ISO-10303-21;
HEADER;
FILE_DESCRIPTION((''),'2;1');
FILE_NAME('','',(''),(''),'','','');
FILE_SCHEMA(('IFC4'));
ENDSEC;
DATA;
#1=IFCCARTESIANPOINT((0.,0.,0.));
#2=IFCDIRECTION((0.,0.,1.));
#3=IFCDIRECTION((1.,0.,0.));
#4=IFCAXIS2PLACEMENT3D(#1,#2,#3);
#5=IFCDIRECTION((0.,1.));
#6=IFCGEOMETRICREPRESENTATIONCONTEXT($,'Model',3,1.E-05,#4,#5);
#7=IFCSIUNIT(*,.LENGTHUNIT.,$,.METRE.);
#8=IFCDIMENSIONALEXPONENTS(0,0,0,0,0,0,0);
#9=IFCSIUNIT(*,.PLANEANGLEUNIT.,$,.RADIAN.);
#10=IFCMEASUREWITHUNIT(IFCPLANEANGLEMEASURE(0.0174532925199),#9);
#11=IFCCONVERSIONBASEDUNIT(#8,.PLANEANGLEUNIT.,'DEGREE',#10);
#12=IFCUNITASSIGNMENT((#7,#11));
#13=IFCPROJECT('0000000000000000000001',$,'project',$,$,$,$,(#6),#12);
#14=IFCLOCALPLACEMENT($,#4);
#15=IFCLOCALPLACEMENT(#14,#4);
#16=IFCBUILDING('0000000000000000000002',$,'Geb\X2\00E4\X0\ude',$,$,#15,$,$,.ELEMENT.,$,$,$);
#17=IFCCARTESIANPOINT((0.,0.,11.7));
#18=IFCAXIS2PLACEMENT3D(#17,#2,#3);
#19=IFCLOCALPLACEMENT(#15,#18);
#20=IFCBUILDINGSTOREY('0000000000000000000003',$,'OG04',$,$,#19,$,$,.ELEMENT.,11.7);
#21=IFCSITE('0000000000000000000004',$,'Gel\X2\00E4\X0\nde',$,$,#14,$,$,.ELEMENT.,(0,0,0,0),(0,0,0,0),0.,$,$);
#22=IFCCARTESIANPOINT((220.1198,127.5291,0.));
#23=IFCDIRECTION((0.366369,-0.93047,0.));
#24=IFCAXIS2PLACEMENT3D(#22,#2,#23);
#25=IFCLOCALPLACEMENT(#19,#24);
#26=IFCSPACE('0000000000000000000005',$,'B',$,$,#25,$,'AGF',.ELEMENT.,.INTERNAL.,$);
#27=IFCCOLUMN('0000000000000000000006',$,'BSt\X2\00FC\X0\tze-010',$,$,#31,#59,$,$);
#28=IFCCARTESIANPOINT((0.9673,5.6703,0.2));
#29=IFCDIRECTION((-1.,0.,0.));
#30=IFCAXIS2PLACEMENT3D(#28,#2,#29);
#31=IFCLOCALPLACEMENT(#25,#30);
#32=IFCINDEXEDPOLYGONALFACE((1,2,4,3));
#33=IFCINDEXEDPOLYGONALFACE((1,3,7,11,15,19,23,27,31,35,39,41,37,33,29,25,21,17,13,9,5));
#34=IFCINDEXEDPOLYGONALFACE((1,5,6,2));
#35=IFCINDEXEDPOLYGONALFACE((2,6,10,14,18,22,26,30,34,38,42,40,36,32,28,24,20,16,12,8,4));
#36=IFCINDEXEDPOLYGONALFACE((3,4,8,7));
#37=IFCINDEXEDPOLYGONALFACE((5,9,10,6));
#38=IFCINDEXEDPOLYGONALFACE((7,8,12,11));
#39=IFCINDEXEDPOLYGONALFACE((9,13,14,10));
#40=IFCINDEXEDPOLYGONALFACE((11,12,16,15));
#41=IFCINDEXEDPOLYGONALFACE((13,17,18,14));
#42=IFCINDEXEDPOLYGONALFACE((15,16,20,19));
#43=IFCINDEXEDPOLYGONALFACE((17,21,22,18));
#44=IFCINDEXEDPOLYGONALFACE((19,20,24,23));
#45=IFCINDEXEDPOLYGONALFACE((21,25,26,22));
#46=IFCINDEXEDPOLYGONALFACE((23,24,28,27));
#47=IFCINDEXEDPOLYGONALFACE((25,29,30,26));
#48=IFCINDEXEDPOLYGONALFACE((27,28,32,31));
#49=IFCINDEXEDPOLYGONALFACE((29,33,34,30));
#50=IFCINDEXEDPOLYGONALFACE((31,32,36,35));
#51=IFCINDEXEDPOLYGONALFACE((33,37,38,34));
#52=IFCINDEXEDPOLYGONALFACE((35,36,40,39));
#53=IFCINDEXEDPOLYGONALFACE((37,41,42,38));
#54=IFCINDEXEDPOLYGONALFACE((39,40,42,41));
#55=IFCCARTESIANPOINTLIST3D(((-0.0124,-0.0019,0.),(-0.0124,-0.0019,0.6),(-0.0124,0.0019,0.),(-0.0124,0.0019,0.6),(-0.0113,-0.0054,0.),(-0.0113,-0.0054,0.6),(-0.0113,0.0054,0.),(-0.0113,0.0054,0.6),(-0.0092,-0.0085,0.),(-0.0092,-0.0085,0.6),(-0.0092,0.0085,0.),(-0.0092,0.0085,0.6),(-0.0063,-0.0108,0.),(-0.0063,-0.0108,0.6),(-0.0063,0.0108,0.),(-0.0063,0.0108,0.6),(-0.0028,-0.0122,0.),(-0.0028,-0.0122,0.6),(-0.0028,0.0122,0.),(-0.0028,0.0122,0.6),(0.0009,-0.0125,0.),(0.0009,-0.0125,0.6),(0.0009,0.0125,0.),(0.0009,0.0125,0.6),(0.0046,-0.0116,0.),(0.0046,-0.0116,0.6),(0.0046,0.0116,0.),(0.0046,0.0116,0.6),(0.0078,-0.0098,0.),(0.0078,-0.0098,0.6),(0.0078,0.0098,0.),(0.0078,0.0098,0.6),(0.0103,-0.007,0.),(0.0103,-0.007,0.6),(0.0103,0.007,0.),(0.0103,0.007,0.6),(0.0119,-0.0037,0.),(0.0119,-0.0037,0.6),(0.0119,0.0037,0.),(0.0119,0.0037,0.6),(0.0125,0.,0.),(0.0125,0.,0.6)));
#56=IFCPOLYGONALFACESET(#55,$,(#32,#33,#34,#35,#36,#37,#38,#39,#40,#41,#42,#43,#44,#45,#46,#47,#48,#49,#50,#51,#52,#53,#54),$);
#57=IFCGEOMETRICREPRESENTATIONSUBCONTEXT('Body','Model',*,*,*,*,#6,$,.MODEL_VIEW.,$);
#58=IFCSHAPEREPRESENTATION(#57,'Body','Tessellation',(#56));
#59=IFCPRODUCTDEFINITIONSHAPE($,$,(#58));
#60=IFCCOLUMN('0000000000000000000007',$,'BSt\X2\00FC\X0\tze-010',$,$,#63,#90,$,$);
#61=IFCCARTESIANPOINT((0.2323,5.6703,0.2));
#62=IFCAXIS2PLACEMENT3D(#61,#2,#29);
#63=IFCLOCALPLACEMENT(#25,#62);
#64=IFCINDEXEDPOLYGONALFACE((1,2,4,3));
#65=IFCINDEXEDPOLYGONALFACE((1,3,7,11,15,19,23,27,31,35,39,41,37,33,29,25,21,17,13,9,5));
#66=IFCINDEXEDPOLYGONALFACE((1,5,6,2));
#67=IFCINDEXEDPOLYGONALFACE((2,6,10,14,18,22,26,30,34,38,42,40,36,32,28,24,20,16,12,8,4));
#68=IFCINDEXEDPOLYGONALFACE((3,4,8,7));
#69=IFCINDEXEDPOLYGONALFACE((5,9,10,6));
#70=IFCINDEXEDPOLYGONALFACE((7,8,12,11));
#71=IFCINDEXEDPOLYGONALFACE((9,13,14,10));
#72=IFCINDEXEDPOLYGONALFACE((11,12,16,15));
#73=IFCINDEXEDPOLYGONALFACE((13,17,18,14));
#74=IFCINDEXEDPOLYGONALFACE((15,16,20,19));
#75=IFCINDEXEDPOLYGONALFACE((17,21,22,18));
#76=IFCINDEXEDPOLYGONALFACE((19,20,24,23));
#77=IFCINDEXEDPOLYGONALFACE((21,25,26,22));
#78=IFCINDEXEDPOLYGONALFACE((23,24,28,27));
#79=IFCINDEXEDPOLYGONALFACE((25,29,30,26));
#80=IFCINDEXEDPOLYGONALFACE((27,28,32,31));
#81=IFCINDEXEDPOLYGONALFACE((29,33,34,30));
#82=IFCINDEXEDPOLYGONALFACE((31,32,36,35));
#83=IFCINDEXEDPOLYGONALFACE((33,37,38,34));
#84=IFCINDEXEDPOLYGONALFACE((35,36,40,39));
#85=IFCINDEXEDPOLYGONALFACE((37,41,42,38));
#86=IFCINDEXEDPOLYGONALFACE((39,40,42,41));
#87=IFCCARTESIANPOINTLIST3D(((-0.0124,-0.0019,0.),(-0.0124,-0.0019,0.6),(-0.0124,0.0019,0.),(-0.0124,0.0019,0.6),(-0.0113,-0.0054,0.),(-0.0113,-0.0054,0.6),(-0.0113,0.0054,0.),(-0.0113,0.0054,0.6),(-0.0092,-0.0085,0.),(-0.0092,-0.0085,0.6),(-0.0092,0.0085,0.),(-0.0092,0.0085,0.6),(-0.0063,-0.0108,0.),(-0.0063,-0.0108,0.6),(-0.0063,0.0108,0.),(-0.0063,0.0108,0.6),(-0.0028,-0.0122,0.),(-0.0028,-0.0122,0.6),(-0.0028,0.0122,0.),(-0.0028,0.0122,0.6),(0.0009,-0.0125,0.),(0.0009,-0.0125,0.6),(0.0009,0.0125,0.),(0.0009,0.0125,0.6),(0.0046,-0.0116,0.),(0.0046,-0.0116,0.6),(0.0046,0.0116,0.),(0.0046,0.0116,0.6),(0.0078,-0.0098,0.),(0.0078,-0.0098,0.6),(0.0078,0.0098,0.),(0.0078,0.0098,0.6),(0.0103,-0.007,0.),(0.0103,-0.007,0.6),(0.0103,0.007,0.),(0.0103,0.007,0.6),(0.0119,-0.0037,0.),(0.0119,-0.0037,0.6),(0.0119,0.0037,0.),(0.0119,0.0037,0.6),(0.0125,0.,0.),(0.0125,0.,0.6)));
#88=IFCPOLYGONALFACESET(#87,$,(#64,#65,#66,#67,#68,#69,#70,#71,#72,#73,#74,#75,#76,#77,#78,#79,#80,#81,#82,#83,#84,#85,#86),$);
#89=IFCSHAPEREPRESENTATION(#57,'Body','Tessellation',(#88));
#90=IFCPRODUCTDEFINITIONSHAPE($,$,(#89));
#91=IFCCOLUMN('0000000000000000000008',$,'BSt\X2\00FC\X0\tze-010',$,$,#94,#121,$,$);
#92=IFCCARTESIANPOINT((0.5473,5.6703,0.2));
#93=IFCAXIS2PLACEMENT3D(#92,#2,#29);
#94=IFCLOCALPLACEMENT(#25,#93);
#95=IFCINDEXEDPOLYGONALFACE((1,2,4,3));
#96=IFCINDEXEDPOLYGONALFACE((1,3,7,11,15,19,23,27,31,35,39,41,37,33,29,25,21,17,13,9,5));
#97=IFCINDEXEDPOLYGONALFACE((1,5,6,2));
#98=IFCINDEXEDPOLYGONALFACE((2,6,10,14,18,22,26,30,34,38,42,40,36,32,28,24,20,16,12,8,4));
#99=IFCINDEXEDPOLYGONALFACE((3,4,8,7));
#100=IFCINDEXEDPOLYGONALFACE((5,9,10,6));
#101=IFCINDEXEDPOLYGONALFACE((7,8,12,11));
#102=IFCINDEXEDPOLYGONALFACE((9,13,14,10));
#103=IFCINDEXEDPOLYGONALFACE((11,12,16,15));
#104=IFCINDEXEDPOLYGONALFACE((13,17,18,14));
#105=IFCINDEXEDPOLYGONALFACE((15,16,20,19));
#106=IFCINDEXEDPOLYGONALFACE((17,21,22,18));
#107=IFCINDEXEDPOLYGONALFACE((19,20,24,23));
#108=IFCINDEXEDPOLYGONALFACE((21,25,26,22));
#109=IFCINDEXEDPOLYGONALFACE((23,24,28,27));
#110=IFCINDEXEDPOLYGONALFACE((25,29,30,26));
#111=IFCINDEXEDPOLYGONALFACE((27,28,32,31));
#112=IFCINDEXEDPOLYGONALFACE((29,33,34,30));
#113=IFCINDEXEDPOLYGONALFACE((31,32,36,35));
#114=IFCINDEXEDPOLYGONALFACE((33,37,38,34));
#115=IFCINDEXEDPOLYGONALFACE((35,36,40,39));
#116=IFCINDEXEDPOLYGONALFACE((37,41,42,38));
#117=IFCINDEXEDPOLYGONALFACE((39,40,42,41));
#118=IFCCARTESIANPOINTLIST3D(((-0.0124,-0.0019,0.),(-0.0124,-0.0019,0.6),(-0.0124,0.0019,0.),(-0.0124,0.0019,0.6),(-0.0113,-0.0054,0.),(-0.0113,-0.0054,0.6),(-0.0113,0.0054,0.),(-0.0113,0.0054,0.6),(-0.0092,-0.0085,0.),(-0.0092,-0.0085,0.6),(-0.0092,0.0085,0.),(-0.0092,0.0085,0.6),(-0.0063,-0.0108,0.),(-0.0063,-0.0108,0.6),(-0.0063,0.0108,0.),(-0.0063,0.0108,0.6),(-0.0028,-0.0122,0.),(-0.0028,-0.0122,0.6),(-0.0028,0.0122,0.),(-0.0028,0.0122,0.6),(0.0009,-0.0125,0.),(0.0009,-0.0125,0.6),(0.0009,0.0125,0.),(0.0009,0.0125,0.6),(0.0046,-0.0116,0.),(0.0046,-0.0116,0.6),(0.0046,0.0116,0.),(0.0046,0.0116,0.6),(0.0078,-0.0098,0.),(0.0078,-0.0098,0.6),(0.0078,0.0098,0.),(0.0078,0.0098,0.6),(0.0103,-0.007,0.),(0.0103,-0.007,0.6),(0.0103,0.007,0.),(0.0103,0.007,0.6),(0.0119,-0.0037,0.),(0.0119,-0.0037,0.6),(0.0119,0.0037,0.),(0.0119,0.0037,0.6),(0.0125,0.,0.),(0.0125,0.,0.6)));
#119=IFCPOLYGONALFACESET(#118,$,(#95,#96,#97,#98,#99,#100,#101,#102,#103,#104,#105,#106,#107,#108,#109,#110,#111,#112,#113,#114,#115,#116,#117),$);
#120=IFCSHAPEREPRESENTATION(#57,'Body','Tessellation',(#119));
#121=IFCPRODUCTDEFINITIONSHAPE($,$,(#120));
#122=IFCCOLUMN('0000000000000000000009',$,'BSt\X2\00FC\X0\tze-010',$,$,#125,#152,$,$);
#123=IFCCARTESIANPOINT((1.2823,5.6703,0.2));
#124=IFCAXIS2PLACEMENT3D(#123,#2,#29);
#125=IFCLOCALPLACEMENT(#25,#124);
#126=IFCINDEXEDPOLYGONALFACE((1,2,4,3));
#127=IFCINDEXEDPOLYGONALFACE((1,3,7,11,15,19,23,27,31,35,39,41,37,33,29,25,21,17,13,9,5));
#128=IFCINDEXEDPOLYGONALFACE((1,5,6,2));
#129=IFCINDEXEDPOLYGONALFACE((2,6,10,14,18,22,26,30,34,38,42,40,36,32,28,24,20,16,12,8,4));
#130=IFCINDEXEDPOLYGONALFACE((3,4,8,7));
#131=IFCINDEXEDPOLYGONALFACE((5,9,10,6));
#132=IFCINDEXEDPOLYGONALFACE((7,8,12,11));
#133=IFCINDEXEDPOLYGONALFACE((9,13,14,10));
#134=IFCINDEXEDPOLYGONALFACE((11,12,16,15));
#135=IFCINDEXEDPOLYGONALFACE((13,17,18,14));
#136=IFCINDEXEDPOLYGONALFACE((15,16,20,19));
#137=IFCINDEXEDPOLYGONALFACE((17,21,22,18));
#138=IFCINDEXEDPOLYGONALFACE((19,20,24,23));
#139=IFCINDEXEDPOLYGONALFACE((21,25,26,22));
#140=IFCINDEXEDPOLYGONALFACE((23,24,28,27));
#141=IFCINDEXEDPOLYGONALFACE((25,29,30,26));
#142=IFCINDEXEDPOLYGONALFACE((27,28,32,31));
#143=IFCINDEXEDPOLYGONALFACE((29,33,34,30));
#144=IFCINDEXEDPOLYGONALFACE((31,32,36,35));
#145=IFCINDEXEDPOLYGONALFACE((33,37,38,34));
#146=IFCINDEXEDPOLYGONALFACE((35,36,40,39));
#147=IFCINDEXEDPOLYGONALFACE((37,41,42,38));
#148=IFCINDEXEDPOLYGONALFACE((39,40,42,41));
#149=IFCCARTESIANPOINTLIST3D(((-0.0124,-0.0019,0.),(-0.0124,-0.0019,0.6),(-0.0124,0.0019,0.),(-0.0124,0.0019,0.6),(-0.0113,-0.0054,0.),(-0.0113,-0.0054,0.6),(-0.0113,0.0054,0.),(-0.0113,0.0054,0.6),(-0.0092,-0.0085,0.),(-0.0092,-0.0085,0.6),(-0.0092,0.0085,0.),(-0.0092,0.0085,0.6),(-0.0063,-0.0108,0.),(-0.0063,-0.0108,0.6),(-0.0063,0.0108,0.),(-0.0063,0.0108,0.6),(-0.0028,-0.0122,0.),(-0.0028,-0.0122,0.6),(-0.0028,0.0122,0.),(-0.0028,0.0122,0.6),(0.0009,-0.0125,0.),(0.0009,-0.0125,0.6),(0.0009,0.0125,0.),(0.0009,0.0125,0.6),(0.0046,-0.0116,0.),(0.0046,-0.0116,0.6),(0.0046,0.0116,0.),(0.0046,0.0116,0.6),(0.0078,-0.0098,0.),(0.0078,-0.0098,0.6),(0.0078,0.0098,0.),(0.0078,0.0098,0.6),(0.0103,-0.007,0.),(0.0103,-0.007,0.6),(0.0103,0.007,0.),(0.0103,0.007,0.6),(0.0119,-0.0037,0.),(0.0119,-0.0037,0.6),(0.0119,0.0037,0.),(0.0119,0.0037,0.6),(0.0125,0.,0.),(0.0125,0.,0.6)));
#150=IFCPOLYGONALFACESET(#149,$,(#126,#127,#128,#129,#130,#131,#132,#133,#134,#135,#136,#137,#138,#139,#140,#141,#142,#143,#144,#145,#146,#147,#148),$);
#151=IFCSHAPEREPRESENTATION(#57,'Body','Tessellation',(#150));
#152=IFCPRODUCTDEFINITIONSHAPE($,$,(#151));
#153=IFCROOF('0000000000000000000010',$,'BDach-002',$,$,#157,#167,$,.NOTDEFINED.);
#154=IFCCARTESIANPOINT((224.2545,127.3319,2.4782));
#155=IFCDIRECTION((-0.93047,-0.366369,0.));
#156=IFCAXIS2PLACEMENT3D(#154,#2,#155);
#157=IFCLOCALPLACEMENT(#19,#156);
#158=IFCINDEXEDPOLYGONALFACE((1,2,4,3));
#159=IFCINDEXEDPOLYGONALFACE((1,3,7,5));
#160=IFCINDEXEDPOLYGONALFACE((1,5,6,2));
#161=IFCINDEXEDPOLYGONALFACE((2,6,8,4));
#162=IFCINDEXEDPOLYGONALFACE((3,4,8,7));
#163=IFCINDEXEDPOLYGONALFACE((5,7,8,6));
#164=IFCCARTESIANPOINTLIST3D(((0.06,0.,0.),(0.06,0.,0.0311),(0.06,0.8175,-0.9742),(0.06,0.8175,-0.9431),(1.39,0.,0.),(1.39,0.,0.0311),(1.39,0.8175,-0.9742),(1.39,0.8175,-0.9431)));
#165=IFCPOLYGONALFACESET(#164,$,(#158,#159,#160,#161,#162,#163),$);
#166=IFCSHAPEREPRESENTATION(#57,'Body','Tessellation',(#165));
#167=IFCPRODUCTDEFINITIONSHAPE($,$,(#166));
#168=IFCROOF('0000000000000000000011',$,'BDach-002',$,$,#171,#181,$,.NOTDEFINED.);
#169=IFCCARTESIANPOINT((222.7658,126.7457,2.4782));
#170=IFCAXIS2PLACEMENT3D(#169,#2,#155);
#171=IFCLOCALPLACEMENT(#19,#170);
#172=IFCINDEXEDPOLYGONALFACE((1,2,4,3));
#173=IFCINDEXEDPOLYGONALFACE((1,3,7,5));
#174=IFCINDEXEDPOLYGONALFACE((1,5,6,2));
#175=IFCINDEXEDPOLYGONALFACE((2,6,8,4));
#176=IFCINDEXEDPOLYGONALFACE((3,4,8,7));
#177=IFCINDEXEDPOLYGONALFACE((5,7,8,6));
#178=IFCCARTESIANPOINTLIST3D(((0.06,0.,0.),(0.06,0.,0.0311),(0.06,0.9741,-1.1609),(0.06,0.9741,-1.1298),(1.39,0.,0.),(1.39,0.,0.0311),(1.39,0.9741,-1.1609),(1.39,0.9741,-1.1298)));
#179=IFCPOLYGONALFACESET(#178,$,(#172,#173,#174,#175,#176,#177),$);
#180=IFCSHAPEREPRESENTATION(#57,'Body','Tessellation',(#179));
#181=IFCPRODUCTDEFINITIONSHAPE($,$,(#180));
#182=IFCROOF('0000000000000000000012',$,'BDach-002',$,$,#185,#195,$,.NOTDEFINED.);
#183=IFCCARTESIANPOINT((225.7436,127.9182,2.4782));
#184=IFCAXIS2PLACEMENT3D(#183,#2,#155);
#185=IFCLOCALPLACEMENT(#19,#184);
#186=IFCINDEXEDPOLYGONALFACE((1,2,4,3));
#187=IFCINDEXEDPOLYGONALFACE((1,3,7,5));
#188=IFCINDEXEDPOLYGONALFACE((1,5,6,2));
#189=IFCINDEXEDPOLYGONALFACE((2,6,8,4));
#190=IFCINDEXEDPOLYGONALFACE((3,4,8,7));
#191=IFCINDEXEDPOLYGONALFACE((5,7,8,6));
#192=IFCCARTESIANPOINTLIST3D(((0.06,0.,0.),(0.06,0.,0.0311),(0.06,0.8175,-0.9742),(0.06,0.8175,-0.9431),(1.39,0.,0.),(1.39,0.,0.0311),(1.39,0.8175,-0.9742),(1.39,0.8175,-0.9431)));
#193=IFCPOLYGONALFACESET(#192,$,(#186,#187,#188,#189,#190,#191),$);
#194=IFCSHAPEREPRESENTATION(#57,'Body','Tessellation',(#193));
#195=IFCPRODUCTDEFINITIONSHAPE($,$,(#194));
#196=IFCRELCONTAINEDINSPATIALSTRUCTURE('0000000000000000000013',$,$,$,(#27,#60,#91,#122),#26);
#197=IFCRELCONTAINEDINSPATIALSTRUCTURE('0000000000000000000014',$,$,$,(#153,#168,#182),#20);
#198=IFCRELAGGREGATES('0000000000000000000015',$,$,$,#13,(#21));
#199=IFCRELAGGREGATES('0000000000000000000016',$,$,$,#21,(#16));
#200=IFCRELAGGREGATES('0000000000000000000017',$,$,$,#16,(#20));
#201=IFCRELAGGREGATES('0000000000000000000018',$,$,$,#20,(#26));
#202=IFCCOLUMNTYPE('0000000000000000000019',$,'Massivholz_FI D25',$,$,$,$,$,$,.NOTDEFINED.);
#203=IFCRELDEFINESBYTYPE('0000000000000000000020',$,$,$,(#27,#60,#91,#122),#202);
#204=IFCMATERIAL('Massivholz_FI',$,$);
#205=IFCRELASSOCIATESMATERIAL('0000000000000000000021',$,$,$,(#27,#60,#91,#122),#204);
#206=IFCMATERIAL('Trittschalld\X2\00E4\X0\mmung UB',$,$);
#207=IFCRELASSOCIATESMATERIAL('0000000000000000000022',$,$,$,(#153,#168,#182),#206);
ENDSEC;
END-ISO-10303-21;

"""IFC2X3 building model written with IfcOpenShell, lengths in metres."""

from ifc_helpers import new_model, entity, si_unit, converted_unit, direction, frame, origin_with_axes, origin_2d_with_axis, place, context, subcontext, project, spatial, polyline, circle, outline, extrude, material, type_object, element, save


model = new_model("IFC2X3")

# Units and contexts
model_context = context("Model", 3, precision=1e-05, world=origin_with_axes(), true_north=direction((0.0, 1.0)))
body_context = subcontext(model_context, "Body", "Model", "MODEL_VIEW")
ifc_project = project(units=[si_unit("LENGTHUNIT", "METRE"), converted_unit("PLANEANGLEUNIT", "DEGREE", entity("IfcPlaneAngleMeasure", 0.0174532925199), si_unit("PLANEANGLEUNIT", "RADIAN"), dimensions=[0, 0, 0, 0, 0, 0, 0])], contexts=[model_context])

# Site, building, storey, space
site_placement = place(None, origin_with_axes())
site = spatial("IfcSite", under=ifc_project, at=site_placement, Name="Gelände", CompositionType="ELEMENT", RefLatitude=(0, 0, 0, 0), RefLongitude=(0, 0, 0, 0), RefElevation=0.0)
building_placement = place(site_placement, origin_with_axes())
building = spatial("IfcBuilding", under=site, at=building_placement, Name="Gebäude", CompositionType="ELEMENT")
storey_placement = place(building_placement, frame((0.0, 0.0, 11.7), z_axis=(0.0, 0.0, 1.0), x_axis=(1.0, 0.0, 0.0)))
storey = spatial("IfcBuildingStorey", under=building, at=storey_placement, Name="OG04", CompositionType="ELEMENT", Elevation=11.7)
space_1_placement = place(storey_placement, frame((220.1198, 127.5291, 0.0), z_axis=(0.0, 0.0, 1.0), x_axis=(0.366369, -0.93047, 0.0)))
space_1 = spatial("IfcSpace", under=storey, at=space_1_placement, Name="B", LongName="AGF", CompositionType="ELEMENT", InteriorOrExteriorSpace="INTERNAL")

# Columns
ifc_material_1 = material(Name="Massivholz_FI")
column_type_1 = type_object("IfcColumnType", Name="Massivholz_FI D25", PredefinedType="NOTDEFINED")
for number, where, z_axis, x_axis, name in (
    (1, (0.9673, 5.6703, 0.2), (0.0, 0.0, 1.0), (-1.0, 0.0, 0.0), "BStütze-010"),
    (2, (0.2323, 5.6703, 0.2), (0.0, 0.0, 1.0), (-1.0, 0.0, 0.0), "BStütze-010"),
    (3, (0.5473, 5.6703, 0.2), (0.0, 0.0, 1.0), (-1.0, 0.0, 0.0), "BStütze-010"),
    (4, (1.2823, 5.6703, 0.2), (0.0, 0.0, 1.0), (-1.0, 0.0, 0.0), "BStütze-010"),
):
    element("IfcColumn", number, at=place(space_1_placement, frame(where, z_axis=z_axis, x_axis=x_axis)), inside=space_1, type_object=column_type_1, material=ifc_material_1, Name=name, context=body_context, shape_type="SweptSolid", body=[
        extrude(circle(Radius=0.0125, at=origin_2d_with_axis()), origin_with_axes(), (0.0, 0.0, 1.0), 0.6),
    ])

# Roofs
ifc_material_2 = material(Name="Trittschalldämmung UB")
roof_1_placement = place(storey_placement, frame((224.2545, 127.3319, 2.4782), z_axis=(0.0, 0.0, 1.0), x_axis=(-0.93047, -0.366369, 0.0)))
element("IfcRoof", 5, at=roof_1_placement, inside=storey, material=ifc_material_2, Name="BDach-002", ShapeType="NOTDEFINED", context=body_context, shape_type="SweptSolid", body=[
    extrude(outline(polyline([(1.39, 0.0), (1.39, 1.2717), (0.06, 1.2717), (0.06, 0.0), (1.39, 0.0)])), frame((0.0, 0.0, 0.0), z_axis=(0.0, 0.766044, 0.642788), x_axis=(1.0, 0.0, 0.0)), (0.0, -0.766044, 0.642788), 0.0311),
])
roof_2_placement = place(storey_placement, frame((222.7658, 126.7457, 2.4782), z_axis=(0.0, 0.0, 1.0), x_axis=(-0.93047, -0.366369, 0.0)))
element("IfcRoof", 6, at=roof_2_placement, inside=storey, material=ifc_material_2, Name="BDach-002", ShapeType="NOTDEFINED", context=body_context, shape_type="SweptSolid", body=[
    extrude(outline(polyline([(1.39, 0.0), (1.39, 1.5154), (0.06, 1.5154), (0.06, 0.0), (1.39, 0.0)])), frame((0.0, 0.0, 0.0), z_axis=(0.0, 0.766044, 0.642788), x_axis=(1.0, 0.0, 0.0)), (0.0, -0.766044, 0.642788), 0.0311),
])
roof_3_placement = place(storey_placement, frame((225.7436, 127.9182, 2.4782), z_axis=(0.0, 0.0, 1.0), x_axis=(-0.93047, -0.366369, 0.0)))
element("IfcRoof", 7, at=roof_3_placement, inside=storey, material=ifc_material_2, Name="BDach-002", ShapeType="NOTDEFINED", context=body_context, shape_type="SweptSolid", body=[
    extrude(outline(polyline([(1.39, 0.0), (1.39, 1.2717), (0.06, 1.2717), (0.06, 0.0), (1.39, 0.0)])), frame((0.0, 0.0, 0.0), z_axis=(0.0, 0.766044, 0.642788), x_axis=(1.0, 0.0, 0.0)), (0.0, -0.766044, 0.642788), 0.0311),
])

save(model, "model.ifc")
